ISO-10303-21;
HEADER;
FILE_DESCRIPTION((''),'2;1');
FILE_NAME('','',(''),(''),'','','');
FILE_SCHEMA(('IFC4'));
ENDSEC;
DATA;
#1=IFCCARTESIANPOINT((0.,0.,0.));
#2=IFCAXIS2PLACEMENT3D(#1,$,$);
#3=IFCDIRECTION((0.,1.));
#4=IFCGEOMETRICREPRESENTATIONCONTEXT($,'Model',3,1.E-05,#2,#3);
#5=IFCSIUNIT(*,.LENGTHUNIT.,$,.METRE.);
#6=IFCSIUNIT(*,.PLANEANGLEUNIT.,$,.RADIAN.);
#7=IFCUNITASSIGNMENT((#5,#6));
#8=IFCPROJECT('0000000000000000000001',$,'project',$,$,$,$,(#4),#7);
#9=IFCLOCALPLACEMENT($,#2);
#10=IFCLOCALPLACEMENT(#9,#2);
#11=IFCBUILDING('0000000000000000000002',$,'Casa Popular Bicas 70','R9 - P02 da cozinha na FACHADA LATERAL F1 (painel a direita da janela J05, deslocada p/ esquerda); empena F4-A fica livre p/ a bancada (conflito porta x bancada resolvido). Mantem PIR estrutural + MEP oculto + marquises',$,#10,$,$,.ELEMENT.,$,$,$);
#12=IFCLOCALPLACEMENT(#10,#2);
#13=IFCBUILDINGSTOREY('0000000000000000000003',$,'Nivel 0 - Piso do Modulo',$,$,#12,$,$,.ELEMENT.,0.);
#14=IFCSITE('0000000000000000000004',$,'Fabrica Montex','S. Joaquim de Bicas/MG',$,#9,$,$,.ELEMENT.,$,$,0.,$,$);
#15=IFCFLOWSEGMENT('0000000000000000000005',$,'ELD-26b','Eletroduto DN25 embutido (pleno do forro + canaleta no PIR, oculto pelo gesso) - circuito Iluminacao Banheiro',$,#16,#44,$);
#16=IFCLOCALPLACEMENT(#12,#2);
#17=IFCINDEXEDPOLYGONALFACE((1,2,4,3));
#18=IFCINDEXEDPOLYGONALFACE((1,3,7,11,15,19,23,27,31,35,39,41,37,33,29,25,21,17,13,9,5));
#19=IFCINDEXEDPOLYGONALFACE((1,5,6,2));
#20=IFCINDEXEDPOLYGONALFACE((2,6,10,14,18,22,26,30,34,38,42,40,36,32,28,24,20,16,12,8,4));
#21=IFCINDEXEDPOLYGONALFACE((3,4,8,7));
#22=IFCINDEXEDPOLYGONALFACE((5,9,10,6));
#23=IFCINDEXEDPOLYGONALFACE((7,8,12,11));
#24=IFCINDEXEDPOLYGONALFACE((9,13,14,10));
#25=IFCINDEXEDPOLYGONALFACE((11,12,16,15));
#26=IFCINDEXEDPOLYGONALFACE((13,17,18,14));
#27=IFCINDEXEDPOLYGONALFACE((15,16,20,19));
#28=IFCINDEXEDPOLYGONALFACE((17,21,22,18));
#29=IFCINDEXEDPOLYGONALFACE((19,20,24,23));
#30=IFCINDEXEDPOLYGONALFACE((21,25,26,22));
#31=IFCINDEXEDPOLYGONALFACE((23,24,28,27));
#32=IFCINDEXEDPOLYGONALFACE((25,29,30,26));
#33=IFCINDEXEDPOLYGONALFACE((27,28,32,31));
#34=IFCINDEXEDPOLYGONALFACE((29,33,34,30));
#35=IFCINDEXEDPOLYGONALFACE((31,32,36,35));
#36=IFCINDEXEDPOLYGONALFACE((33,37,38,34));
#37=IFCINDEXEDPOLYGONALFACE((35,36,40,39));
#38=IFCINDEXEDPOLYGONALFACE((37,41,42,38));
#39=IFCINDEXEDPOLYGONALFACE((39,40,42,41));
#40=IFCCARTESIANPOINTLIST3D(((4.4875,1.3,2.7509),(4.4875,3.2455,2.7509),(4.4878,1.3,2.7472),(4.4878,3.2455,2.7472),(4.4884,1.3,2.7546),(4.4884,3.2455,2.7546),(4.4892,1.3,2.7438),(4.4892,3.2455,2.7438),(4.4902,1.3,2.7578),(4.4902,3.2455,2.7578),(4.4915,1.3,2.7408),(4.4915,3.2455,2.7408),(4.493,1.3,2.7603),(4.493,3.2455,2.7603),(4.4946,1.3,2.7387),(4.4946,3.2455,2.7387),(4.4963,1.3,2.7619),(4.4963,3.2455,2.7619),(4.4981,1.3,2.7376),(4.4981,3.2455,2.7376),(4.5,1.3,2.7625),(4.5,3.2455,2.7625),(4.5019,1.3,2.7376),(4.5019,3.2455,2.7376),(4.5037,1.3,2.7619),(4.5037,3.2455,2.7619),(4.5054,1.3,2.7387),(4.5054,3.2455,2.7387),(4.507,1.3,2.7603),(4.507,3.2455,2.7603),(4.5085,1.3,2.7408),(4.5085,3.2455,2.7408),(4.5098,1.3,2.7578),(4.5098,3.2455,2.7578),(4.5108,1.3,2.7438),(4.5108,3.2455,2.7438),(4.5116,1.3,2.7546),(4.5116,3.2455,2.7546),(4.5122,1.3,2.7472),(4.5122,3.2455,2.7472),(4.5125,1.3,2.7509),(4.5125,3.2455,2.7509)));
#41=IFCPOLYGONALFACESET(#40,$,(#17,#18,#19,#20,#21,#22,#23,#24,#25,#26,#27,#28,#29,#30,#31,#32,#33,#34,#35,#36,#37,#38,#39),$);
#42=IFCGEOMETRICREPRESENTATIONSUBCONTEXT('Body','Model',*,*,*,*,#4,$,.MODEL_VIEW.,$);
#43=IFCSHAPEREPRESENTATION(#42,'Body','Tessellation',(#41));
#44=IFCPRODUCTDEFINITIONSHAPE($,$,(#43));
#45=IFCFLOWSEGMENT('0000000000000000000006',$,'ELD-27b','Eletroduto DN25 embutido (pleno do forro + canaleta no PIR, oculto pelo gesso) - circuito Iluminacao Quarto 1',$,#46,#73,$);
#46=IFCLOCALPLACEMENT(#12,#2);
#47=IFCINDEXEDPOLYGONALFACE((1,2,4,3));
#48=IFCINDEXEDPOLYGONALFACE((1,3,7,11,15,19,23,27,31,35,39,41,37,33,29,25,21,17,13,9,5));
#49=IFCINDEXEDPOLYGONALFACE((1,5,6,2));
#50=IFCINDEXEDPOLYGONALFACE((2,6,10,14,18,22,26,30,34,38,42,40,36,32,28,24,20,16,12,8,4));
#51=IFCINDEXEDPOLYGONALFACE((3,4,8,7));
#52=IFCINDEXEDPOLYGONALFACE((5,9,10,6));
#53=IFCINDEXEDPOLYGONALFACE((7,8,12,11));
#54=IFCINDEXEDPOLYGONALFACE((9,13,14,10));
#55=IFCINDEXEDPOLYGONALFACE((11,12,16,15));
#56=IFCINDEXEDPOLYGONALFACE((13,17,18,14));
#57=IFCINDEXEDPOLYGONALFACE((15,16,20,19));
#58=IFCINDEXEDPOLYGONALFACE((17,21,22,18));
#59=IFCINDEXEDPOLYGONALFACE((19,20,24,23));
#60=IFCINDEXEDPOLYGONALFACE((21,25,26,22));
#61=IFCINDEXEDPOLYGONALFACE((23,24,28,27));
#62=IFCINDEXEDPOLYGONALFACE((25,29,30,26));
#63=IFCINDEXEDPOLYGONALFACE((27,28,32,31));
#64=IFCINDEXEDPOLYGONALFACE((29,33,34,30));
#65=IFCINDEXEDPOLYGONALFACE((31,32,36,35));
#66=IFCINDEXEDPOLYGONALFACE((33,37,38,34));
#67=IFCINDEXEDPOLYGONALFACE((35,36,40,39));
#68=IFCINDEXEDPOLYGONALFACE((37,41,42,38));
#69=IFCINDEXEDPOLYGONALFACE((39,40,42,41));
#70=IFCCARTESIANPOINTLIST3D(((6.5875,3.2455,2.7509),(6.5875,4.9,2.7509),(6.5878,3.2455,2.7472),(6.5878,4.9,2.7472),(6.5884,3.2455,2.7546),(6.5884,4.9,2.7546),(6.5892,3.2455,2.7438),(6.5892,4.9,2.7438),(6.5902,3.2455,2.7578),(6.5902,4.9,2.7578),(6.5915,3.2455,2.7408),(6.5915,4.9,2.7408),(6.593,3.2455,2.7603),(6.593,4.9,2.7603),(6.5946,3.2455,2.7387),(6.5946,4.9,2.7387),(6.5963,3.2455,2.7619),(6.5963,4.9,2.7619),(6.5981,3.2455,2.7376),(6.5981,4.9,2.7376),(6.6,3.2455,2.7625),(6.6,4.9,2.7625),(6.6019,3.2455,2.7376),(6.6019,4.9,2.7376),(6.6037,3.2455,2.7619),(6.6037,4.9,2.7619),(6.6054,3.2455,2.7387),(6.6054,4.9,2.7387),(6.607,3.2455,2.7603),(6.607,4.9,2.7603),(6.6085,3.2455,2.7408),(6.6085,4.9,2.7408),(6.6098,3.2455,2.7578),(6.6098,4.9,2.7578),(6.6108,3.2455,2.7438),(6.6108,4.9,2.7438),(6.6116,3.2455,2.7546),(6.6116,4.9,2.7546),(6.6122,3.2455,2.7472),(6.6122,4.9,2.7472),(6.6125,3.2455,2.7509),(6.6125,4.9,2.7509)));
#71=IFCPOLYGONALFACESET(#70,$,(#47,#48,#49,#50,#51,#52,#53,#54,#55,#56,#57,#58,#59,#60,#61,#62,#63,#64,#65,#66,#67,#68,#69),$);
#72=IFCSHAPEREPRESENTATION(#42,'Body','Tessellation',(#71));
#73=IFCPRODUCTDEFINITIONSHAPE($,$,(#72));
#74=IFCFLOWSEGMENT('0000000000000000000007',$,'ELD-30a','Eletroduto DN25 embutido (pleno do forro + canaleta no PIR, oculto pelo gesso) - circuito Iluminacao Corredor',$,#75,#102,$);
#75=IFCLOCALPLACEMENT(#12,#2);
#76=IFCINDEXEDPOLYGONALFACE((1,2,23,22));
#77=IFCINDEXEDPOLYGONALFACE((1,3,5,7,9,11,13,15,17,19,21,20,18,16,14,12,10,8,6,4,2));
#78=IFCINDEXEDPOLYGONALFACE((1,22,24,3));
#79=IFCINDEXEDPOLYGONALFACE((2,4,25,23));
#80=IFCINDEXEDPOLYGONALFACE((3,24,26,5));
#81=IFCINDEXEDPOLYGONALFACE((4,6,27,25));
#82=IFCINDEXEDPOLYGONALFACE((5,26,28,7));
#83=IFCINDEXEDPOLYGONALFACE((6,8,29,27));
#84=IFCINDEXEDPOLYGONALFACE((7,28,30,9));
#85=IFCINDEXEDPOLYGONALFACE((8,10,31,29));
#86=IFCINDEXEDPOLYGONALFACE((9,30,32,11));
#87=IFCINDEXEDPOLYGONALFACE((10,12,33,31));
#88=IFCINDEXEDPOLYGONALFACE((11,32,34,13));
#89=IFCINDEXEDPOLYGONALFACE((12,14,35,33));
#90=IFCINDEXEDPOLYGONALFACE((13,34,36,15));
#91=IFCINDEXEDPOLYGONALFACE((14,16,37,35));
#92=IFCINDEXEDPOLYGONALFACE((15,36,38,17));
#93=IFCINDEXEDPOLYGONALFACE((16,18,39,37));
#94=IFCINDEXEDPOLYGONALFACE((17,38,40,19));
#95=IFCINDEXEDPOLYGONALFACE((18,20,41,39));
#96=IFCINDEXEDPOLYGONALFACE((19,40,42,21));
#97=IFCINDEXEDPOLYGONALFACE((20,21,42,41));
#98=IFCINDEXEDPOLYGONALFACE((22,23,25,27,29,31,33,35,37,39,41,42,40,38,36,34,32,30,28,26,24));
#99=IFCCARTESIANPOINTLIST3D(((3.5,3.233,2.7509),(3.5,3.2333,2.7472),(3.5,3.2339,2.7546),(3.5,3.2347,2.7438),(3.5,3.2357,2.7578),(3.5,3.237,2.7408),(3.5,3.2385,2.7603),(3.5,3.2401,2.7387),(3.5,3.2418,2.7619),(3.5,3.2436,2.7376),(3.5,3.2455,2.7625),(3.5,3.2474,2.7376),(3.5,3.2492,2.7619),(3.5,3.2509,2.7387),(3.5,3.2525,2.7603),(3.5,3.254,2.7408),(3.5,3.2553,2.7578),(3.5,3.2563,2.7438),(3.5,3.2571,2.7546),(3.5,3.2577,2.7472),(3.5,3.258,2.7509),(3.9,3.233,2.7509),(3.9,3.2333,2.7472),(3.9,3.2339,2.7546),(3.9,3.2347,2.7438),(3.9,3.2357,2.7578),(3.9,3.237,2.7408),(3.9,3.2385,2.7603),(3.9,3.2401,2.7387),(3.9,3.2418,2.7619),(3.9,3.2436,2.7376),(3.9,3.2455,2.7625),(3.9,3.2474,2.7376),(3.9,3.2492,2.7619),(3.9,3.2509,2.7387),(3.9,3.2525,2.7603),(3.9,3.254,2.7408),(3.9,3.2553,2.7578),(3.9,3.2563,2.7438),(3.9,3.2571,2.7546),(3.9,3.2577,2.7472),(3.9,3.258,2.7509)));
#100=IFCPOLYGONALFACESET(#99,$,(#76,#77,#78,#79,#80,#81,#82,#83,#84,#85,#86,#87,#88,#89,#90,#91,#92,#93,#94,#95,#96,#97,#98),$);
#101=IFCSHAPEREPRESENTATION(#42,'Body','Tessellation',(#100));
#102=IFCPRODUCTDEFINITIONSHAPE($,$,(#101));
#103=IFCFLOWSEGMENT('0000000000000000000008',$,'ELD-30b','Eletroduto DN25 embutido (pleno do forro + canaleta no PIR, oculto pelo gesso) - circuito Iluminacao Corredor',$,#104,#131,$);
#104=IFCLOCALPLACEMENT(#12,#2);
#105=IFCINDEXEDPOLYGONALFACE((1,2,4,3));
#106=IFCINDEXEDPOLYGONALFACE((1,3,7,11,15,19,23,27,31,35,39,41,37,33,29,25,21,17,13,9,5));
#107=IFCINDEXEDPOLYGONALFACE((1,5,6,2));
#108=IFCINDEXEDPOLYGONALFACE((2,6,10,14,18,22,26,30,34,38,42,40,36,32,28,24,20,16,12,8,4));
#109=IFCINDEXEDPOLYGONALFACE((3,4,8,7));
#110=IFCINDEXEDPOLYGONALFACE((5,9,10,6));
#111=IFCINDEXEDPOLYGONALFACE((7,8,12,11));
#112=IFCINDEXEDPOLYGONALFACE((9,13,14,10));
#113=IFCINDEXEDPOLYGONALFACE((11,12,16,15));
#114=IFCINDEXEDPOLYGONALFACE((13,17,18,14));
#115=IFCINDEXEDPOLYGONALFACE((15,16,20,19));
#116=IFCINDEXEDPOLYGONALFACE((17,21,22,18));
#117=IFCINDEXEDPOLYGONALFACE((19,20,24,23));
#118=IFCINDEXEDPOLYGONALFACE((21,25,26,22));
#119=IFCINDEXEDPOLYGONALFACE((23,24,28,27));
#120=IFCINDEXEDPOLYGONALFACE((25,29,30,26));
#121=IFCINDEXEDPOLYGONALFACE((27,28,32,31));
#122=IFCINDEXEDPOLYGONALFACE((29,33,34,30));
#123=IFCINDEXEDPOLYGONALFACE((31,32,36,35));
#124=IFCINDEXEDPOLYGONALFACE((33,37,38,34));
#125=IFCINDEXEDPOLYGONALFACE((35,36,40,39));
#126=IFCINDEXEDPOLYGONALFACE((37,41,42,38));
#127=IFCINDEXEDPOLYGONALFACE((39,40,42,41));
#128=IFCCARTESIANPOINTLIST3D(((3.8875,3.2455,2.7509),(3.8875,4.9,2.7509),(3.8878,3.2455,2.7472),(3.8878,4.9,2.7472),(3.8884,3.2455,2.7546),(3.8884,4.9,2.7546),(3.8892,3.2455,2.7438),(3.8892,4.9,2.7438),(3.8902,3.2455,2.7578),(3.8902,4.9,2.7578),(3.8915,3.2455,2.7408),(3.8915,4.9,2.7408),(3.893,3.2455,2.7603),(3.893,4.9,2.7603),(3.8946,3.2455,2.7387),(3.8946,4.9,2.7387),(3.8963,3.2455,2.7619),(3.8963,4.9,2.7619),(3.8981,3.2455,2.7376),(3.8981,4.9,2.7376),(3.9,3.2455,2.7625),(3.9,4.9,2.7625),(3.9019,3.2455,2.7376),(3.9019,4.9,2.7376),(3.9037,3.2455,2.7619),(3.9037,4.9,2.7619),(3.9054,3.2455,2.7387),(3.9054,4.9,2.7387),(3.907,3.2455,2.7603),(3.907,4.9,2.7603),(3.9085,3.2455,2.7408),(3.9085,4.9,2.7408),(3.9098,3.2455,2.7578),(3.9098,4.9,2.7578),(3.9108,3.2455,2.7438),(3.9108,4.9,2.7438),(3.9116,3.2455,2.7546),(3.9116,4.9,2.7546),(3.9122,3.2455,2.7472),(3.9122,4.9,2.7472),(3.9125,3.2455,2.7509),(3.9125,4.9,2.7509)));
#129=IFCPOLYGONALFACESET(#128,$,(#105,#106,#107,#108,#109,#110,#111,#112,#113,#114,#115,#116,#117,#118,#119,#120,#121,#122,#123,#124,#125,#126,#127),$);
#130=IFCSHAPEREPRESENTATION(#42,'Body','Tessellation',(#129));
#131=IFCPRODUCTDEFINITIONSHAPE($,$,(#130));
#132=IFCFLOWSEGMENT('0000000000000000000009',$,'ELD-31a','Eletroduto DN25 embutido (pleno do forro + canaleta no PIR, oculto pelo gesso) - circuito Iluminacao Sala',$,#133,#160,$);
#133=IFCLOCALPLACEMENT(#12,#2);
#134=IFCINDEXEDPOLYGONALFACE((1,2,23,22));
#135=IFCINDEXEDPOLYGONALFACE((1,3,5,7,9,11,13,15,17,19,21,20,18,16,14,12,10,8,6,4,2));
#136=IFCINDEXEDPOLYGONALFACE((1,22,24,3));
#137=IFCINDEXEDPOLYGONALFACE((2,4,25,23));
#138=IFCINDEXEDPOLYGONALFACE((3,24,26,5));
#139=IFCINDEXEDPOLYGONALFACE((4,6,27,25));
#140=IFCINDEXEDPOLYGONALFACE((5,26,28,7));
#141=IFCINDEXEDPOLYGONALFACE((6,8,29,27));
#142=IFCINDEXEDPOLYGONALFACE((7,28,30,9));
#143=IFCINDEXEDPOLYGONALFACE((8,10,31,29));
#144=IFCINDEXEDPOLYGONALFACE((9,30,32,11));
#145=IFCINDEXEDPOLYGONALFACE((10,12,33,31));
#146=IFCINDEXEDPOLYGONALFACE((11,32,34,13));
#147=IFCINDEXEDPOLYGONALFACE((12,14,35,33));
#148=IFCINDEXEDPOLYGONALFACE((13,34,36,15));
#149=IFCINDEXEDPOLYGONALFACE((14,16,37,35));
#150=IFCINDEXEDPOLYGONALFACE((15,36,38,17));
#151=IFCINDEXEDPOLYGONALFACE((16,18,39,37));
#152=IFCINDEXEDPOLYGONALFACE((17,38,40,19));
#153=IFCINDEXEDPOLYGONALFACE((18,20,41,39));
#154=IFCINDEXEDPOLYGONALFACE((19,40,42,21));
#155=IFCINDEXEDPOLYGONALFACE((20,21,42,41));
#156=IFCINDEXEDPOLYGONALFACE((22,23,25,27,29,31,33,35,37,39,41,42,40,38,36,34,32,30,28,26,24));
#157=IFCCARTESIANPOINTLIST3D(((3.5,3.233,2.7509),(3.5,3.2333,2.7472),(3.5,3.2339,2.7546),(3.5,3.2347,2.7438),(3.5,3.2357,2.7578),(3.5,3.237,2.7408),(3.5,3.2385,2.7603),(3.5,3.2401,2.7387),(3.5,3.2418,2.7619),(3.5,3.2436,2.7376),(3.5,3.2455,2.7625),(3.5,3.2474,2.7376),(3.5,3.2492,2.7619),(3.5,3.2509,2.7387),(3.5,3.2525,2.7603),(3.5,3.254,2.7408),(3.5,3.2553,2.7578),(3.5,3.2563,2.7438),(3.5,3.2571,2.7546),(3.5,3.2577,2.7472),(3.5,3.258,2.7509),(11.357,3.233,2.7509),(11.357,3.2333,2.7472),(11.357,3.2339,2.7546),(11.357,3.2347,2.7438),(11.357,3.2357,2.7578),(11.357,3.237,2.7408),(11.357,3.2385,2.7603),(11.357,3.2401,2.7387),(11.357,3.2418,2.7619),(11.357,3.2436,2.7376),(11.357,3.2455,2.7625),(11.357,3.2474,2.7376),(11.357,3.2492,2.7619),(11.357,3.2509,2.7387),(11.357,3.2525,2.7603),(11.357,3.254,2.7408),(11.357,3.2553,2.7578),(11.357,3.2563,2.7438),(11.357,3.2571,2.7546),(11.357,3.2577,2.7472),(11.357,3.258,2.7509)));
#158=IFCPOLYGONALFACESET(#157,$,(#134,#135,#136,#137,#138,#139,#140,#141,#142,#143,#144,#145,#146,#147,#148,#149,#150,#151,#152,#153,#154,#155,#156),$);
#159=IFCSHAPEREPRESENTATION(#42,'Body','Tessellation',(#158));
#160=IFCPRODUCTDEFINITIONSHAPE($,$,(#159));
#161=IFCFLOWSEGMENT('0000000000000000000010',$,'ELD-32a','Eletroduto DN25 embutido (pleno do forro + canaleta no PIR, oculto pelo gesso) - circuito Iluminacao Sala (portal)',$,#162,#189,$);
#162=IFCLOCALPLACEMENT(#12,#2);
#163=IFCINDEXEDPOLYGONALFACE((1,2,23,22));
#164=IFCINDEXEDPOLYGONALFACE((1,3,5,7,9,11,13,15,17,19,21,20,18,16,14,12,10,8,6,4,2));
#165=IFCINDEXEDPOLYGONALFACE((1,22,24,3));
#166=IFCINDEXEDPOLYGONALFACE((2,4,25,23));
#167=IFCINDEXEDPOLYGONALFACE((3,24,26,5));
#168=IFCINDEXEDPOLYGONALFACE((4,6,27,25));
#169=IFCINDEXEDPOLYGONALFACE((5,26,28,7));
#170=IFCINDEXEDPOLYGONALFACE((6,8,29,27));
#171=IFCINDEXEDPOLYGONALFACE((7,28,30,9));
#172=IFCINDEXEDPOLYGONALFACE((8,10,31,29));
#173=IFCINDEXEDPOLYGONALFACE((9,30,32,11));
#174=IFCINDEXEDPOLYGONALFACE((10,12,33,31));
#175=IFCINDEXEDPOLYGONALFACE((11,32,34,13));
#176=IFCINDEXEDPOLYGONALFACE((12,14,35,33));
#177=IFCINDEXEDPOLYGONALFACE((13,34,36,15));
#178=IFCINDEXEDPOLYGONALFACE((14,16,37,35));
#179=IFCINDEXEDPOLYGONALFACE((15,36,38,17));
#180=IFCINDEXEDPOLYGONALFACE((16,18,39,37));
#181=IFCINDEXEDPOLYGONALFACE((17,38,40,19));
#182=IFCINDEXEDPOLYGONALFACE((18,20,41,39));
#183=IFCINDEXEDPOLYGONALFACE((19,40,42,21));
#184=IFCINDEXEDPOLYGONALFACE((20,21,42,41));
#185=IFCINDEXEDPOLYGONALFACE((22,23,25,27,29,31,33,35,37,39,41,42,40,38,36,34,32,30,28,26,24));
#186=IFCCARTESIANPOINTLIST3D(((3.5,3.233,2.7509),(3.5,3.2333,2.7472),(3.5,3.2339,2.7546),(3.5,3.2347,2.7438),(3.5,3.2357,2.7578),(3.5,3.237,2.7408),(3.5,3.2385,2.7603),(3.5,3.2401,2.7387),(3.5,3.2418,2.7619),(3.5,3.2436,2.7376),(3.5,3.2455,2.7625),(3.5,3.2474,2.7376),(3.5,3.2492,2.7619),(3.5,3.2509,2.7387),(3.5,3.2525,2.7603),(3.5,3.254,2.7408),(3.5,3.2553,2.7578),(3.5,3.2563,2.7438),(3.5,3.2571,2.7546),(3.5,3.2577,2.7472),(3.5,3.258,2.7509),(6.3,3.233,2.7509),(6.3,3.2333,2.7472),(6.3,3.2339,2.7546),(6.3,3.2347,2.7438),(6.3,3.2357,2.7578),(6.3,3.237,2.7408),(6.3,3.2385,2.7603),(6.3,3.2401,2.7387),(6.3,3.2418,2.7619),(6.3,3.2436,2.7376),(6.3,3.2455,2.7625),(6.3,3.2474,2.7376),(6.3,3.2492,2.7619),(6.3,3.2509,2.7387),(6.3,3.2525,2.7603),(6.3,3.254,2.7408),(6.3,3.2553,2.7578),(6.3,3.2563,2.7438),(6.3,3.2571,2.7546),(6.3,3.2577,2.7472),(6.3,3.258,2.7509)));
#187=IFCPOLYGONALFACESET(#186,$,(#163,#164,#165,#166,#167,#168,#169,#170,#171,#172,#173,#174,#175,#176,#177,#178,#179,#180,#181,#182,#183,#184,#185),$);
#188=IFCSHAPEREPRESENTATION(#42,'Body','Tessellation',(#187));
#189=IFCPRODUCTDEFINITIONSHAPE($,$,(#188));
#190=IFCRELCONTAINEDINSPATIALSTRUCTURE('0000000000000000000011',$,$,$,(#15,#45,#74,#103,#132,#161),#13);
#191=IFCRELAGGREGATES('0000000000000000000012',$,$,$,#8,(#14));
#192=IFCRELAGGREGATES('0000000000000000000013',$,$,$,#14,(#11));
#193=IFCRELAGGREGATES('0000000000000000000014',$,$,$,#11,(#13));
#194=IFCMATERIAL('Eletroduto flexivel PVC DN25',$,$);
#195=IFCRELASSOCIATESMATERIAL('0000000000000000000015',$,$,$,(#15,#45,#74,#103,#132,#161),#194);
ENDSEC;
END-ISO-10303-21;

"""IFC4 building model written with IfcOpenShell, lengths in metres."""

from ifc_helpers import new_model, si_unit, direction, frame, origin, origin_2d, place, context, subcontext, project, spatial, circle, extrude, material, element, save


model = new_model("IFC4")

# Units and contexts
model_context = context("Model", 3, precision=1e-05, world=origin(), true_north=direction((0.0, 1.0)))
body_context = subcontext(model_context, "Body", "Model", "MODEL_VIEW")
ifc_project = project(units=[si_unit("LENGTHUNIT", "METRE"), si_unit("PLANEANGLEUNIT", "RADIAN")], contexts=[model_context])

# Site, building, storey
site_placement = place(None, origin())
site = spatial("IfcSite", under=ifc_project, at=site_placement, Name="Fabrica Montex", Description="S. Joaquim de Bicas/MG", CompositionType="ELEMENT", RefElevation=0.0)
building_placement = place(site_placement, origin())
building = spatial("IfcBuilding", under=site, at=building_placement, Name="Casa Popular Bicas 70", Description="R9 - P02 da cozinha na FACHADA LATERAL F1 (painel a direita da janela J05, deslocada p/ esquerda); empena F4-A fica livre p/ a bancada (conflito porta x bancada resolvido). Mantem PIR estrutural + MEP oculto + marquises", CompositionType="ELEMENT")
storey_placement = place(building_placement, origin())
storey = spatial("IfcBuildingStorey", under=building, at=storey_placement, Name="Nivel 0 - Piso do Modulo", CompositionType="ELEMENT", Elevation=0.0)

# Flow segments
ifc_material_1 = material(Name="Eletroduto flexivel PVC DN25")
flow_segment_1_placement = place(storey_placement, frame((4.5, 3.2455, 2.75), z_axis=(0.0, -1.0, 0.0), x_axis=(0.0, 0.0, 1.0)))
element("IfcFlowSegment", 1, at=flow_segment_1_placement, inside=storey, material=ifc_material_1, Name="ELD-26b", Description="Eletroduto DN25 embutido (pleno do forro + canaleta no PIR, oculto pelo gesso) - circuito Iluminacao Banheiro", context=body_context, shape_type="SweptSolid", body=[
    extrude(circle(Radius=0.0125, at=origin_2d()), origin(), (0.0, 0.0, 1.0), 1.9455),
])
flow_segment_2_placement = place(storey_placement, frame((6.6, 3.2455, 2.75), z_axis=(0.0, 1.0, 0.0), x_axis=(0.0, 0.0, 1.0)))
element("IfcFlowSegment", 2, at=flow_segment_2_placement, inside=storey, material=ifc_material_1, Name="ELD-27b", Description="Eletroduto DN25 embutido (pleno do forro + canaleta no PIR, oculto pelo gesso) - circuito Iluminacao Quarto 1", context=body_context, shape_type="SweptSolid", body=[
    extrude(circle(Radius=0.0125, at=origin_2d()), origin(), (0.0, 0.0, 1.0), 1.6545),
])
flow_segment_3_placement = place(storey_placement, frame((3.5, 3.2455, 2.75), z_axis=(1.0, 0.0, 0.0), x_axis=(0.0, 0.0, 1.0)))
element("IfcFlowSegment", 3, at=flow_segment_3_placement, inside=storey, material=ifc_material_1, Name="ELD-30a", Description="Eletroduto DN25 embutido (pleno do forro + canaleta no PIR, oculto pelo gesso) - circuito Iluminacao Corredor", context=body_context, shape_type="SweptSolid", body=[
    extrude(circle(Radius=0.0125, at=origin_2d()), origin(), (0.0, 0.0, 1.0), 0.4),
])
flow_segment_4_placement = place(storey_placement, frame((3.9, 3.2455, 2.75), z_axis=(0.0, 1.0, 0.0), x_axis=(0.0, 0.0, 1.0)))
element("IfcFlowSegment", 4, at=flow_segment_4_placement, inside=storey, material=ifc_material_1, Name="ELD-30b", Description="Eletroduto DN25 embutido (pleno do forro + canaleta no PIR, oculto pelo gesso) - circuito Iluminacao Corredor", context=body_context, shape_type="SweptSolid", body=[
    extrude(circle(Radius=0.0125, at=origin_2d()), origin(), (0.0, 0.0, 1.0), 1.6545),
])
flow_segment_5_placement = place(storey_placement, frame((3.5, 3.2455, 2.75), z_axis=(1.0, 0.0, 0.0), x_axis=(0.0, 0.0, 1.0)))
element("IfcFlowSegment", 5, at=flow_segment_5_placement, inside=storey, material=ifc_material_1, Name="ELD-31a", Description="Eletroduto DN25 embutido (pleno do forro + canaleta no PIR, oculto pelo gesso) - circuito Iluminacao Sala", context=body_context, shape_type="SweptSolid", body=[
    extrude(circle(Radius=0.0125, at=origin_2d()), origin(), (0.0, 0.0, 1.0), 7.857),
])
flow_segment_6_placement = place(storey_placement, frame((3.5, 3.2455, 2.75), z_axis=(1.0, 0.0, 0.0), x_axis=(0.0, 0.0, 1.0)))
element("IfcFlowSegment", 6, at=flow_segment_6_placement, inside=storey, material=ifc_material_1, Name="ELD-32a", Description="Eletroduto DN25 embutido (pleno do forro + canaleta no PIR, oculto pelo gesso) - circuito Iluminacao Sala (portal)", context=body_context, shape_type="SweptSolid", body=[
    extrude(circle(Radius=0.0125, at=origin_2d()), origin(), (0.0, 0.0, 1.0), 2.8),
])

save(model, "model.ifc")
